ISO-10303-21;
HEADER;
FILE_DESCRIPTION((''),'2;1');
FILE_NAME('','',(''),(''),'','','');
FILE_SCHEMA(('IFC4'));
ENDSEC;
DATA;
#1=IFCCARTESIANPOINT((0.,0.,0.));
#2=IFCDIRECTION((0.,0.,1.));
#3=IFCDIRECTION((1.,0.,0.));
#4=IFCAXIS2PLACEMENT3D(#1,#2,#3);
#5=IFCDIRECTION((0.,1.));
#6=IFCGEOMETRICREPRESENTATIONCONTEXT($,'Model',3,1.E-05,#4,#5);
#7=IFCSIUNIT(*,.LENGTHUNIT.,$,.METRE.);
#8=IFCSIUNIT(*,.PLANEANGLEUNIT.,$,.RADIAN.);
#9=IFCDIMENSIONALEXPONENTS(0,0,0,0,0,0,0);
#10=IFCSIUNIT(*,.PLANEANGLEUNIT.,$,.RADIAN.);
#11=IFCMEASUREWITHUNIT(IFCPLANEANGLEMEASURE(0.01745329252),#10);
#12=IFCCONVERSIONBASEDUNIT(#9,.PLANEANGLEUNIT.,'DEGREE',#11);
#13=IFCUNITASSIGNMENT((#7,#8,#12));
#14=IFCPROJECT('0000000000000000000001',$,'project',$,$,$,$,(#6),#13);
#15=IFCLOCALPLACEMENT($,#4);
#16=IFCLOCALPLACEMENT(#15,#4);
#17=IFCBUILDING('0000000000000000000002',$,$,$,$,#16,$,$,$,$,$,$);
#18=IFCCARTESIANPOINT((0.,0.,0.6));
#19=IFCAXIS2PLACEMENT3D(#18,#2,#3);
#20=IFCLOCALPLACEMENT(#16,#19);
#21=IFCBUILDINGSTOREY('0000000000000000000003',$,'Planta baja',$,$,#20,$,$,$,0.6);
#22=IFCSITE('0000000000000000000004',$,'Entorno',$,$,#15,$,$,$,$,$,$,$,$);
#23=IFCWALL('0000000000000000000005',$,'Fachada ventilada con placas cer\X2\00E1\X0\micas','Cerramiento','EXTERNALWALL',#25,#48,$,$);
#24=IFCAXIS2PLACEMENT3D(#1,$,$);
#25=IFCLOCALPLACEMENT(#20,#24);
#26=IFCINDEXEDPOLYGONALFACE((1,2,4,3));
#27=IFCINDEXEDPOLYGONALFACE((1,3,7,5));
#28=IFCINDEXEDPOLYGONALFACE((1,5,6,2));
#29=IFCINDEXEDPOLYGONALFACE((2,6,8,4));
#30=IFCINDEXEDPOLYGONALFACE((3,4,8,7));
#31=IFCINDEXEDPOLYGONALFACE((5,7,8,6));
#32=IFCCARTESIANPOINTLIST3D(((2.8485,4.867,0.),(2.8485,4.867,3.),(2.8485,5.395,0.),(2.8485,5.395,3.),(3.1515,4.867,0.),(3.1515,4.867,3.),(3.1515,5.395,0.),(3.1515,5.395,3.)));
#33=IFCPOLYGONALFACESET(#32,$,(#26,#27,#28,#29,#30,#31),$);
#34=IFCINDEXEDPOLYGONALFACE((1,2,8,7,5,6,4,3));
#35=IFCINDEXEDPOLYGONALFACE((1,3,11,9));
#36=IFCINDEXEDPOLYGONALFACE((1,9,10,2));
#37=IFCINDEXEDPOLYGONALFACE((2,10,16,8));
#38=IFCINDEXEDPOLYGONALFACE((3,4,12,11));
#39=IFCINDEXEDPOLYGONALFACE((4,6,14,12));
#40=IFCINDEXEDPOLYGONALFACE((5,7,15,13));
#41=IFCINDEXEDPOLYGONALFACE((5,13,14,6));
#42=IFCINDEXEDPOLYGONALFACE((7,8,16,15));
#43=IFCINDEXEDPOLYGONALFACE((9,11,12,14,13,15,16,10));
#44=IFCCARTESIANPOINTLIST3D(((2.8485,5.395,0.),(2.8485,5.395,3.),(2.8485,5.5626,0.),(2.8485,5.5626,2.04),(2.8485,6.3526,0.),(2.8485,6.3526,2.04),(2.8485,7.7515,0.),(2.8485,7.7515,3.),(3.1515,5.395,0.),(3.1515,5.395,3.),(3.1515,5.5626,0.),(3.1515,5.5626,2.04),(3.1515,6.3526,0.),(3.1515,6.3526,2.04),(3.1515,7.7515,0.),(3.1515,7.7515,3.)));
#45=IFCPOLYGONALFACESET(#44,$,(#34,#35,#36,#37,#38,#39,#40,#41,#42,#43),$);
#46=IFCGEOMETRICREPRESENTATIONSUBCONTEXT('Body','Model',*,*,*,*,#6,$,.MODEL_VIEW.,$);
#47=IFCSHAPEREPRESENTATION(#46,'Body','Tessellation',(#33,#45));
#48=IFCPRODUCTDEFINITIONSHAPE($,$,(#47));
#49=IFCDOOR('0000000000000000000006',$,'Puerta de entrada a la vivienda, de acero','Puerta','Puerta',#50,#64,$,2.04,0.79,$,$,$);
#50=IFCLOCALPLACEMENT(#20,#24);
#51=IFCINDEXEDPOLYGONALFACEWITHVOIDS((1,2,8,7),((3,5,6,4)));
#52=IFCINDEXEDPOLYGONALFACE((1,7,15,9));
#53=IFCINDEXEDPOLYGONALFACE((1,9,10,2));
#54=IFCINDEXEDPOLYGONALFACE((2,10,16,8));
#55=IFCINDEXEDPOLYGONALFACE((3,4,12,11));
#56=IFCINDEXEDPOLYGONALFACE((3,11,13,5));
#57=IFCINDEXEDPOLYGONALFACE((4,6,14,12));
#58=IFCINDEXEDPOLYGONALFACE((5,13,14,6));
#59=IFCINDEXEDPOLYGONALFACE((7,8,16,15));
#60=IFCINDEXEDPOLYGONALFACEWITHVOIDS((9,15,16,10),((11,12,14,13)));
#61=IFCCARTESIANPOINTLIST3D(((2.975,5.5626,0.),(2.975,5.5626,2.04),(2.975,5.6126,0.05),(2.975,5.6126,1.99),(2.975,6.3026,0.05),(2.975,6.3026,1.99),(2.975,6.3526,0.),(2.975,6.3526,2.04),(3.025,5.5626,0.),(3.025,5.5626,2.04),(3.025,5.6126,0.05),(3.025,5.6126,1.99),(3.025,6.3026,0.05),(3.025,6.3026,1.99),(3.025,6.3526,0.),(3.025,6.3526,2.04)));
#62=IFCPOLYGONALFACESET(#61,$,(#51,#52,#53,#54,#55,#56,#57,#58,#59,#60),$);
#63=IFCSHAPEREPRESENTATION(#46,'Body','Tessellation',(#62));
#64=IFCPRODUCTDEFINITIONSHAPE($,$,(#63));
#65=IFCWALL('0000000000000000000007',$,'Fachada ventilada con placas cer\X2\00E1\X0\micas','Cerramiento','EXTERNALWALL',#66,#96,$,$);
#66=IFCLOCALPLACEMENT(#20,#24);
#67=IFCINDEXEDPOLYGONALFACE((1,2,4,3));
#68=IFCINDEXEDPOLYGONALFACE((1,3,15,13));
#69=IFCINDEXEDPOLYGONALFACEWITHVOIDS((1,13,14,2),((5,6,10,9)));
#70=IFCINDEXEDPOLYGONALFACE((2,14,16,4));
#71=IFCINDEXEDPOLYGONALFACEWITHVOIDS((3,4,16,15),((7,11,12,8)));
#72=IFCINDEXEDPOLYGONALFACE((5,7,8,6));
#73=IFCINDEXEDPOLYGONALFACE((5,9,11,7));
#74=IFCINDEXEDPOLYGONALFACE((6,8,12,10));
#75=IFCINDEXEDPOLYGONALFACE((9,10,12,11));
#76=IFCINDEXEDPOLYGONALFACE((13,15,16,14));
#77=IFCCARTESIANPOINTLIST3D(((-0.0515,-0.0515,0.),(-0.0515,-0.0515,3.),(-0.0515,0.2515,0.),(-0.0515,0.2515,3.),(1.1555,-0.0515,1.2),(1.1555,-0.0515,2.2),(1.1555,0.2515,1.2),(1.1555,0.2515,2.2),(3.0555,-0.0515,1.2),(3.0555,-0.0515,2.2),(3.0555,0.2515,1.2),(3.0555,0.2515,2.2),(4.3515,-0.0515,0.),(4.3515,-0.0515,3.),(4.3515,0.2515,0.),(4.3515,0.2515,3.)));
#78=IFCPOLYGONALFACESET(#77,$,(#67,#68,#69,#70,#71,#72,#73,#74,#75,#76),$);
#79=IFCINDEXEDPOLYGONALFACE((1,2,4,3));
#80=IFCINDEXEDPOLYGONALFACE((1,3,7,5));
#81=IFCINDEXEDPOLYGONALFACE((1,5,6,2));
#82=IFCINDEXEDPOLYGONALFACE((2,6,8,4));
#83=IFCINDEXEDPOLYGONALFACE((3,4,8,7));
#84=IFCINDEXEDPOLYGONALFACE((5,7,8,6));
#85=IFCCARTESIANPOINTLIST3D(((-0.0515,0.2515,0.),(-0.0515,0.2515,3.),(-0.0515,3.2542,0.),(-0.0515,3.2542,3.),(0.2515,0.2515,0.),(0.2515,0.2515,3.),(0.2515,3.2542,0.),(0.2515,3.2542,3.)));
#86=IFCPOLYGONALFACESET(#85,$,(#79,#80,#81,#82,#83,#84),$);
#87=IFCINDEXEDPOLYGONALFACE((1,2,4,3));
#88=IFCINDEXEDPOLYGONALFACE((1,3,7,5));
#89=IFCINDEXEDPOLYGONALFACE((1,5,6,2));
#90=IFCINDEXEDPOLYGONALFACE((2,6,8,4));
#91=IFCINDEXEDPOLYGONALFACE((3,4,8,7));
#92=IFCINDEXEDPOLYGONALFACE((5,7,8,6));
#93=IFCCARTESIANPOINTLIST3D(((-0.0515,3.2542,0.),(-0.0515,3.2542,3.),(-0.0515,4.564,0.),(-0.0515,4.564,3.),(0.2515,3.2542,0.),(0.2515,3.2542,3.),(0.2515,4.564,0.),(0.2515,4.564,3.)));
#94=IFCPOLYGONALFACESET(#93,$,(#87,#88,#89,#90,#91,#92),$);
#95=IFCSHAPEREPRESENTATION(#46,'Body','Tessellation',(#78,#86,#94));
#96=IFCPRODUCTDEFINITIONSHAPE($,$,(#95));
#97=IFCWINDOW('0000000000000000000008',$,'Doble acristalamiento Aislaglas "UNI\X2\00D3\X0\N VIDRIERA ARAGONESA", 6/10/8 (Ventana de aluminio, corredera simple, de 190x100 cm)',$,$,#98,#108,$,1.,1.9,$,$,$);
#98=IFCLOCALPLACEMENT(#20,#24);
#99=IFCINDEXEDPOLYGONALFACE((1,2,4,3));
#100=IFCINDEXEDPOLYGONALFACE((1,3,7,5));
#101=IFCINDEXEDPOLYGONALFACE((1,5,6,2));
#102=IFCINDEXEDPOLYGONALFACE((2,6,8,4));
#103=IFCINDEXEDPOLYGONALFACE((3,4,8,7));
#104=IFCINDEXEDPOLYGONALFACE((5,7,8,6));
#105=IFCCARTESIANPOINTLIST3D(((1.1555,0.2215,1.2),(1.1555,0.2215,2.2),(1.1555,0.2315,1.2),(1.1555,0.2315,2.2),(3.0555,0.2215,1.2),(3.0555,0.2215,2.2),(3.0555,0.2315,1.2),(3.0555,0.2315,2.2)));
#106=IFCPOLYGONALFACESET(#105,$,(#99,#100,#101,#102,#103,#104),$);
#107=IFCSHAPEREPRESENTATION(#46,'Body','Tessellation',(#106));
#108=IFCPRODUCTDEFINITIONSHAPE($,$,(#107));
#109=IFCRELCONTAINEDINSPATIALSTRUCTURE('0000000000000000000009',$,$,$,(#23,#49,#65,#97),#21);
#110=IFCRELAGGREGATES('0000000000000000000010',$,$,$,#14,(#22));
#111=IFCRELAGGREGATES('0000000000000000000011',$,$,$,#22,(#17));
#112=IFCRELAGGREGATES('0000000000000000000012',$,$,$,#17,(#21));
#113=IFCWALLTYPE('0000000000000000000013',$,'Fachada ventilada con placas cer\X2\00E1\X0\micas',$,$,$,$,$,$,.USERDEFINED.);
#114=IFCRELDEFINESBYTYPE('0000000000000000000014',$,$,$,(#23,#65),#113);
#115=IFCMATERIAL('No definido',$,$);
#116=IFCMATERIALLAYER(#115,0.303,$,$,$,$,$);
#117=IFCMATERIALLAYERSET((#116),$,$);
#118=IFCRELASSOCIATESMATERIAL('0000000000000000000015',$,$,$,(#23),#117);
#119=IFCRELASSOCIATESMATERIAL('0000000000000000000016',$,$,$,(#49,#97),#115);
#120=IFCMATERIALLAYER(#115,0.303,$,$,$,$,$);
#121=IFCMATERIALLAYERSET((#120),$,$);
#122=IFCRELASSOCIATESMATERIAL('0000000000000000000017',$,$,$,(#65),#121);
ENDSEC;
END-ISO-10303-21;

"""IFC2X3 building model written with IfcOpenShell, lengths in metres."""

from ifc_helpers import new_model, entity, si_unit, converted_unit, direction, frame, origin_with_axes, origin_2d_with_axis, place, context, subcontext, project, spatial, polyline, rectangle, hollow_rectangle, outline, extrude, shape, material, layer, layer_set, layer_usage, type_object, element, fill, save


model = new_model("IFC2X3")

# Units and contexts
model_context = context("Model", 3, precision=1e-05, world=origin_with_axes(), true_north=direction((0.0, 1.0)))
body_context = subcontext(model_context, "Body", "Model", "MODEL_VIEW")
footprint_context = subcontext(model_context, "FootPrint", "Model", "MODEL_VIEW")
ifc_project = project(units=[si_unit("LENGTHUNIT", "METRE"), si_unit("PLANEANGLEUNIT", "RADIAN"), converted_unit("PLANEANGLEUNIT", "DEGREE", entity("IfcPlaneAngleMeasure", 0.01745329252), si_unit("PLANEANGLEUNIT", "RADIAN"), dimensions=[0, 0, 0, 0, 0, 0, 0])], contexts=[model_context])

# Site, building, storey
site_placement = place(None, origin_with_axes())
site = spatial("IfcSite", under=ifc_project, at=site_placement, Name="Entorno")
building_placement = place(site_placement, origin_with_axes())
building = spatial("IfcBuilding", under=site, at=building_placement)
storey_placement = place(building_placement, frame((0.0, 0.0, 0.6), z_axis=(0.0, 0.0, 1.0), x_axis=(1.0, 0.0, 0.0)))
storey = spatial("IfcBuildingStorey", under=building, at=storey_placement, Name="Planta baja", Elevation=0.6)

# Shared definitions
ifc_material = material(Name="No definido")

# Shared definitions
wall_type_1 = type_object("IfcWallType", Name="Fachada ventilada con placas cerámicas", PredefinedType="USERDEFINED")

# Wall, opening, door
ifc_layer_1 = layer(ifc_material, 0.303)
ifc_layer_set_1 = layer_set([ifc_layer_1])
ifc_layer_usage_1 = layer_usage(ifc_layer_set_1, "AXIS2", "POSITIVE", -0.1515)
wall_1_placement = place(storey_placement, frame((3.0, 4.7155, 0.0), z_axis=(0.0, 0.0, 1.0), x_axis=(0.0, 1.0, 0.0)))
wall_1 = element("IfcWall", 1, at=wall_1_placement, inside=storey, type_object=wall_type_1, material=ifc_layer_usage_1, Name="Fachada ventilada con placas cerámicas", Description="Cerramiento", ObjectType="EXTERNALWALL", context=body_context, shape_type="SolidModel", body=[
    extrude(outline(polyline([(-0.264, -1.5), (0.264, -1.5), (0.264, 1.5), (-0.264, 1.5), (-0.264, -1.5)])), frame((0.4155, 0.1515, 1.5), z_axis=(0.0, -1.0, 0.0), x_axis=(1.0, 0.0, 0.0)), (0.0, 0.0, 1.0), 0.303),
    extrude(outline(polyline([(-1.1783, -1.5), (1.1783, -1.5), (1.1783, 1.5), (-1.1783, 1.5), (-1.1783, -1.5)])), frame((1.8578, 0.1515, 1.5), z_axis=(0.0, -1.0, 0.0), x_axis=(1.0, 0.0, 0.0)), (0.0, 0.0, 1.0), 0.303),
])
opening_1_placement = place(wall_1_placement, frame((1.2421, 0.0, 1.02), z_axis=(0.0, 0.0, 1.0), x_axis=(1.0, 0.0, 0.0)))
cartesian_point_1 = entity("IfcCartesianPoint", [-0.395, -0.1515])
opening_1 = element("IfcOpeningElement", 2, at=opening_1_placement, cuts=wall_1, ObjectType="No definido", shapes=[
    shape(body_context, "Body", "SweptSolid", [extrude(rectangle(XDim=2.04, YDim=0.79, at=origin_2d_with_axis()), frame((0.0, -0.1515, 0.0), z_axis=(0.0, 1.0, 0.0), x_axis=(0.0, 0.0, 1.0)), (0.0, 0.0, 1.0), 0.303)]),
    shape(footprint_context, "FootPrint", "GeometricCurveSet", [entity("IfcGeometricCurveSet", [entity("IfcPolyline", [cartesian_point_1, entity("IfcCartesianPoint", [0.395, -0.1515]), entity("IfcCartesianPoint", [0.395, 0.1515]), entity("IfcCartesianPoint", [-0.395, 0.1515]), cartesian_point_1])])]),
])
door_1_placement = place(opening_1_placement, origin_with_axes())
door_1 = element("IfcDoor", 3, at=door_1_placement, inside=storey, material=ifc_material, Name="Puerta de entrada a la vivienda, de acero", Description="Puerta", ObjectType="Puerta", OverallHeight=2.04, OverallWidth=0.79, context=body_context, shape_type="SweptSolid", body=[
    extrude(hollow_rectangle(XDim=0.79, YDim=2.04, WallThickness=0.05, InnerFilletRadius=0.0, OuterFilletRadius=0.0, at=origin_2d_with_axis()), frame((0.0, 0.025, 0.0), z_axis=(0.0, -1.0, 0.0), x_axis=(1.0, 0.0, 0.0)), (0.0, 0.0, 1.0), 0.05),
])
fill(opening_1, door_1)

# Wall, opening, window
ifc_layer_2 = layer(ifc_material, 0.303)
ifc_layer_set_2 = layer_set([ifc_layer_2])
ifc_layer_usage_2 = layer_usage(ifc_layer_set_2, "AXIS2", "POSITIVE", -0.1515)
wall_2_placement = place(storey_placement, frame((4.2, 0.1, 0.0), z_axis=(0.0, 0.0, 1.0), x_axis=(-1.0, 0.0, 0.0)))
wall_2 = element("IfcWall", 4, at=wall_2_placement, inside=storey, type_object=wall_type_1, material=ifc_layer_usage_2, Name="Fachada ventilada con placas cerámicas", Description="Cerramiento", ObjectType="EXTERNALWALL", context=body_context, shape_type="SolidModel", body=[
    extrude(outline(polyline([(-2.2015, -1.5), (2.2015, -1.5), (2.2015, 1.5), (-2.2015, 1.5), (-2.2015, -1.5)])), frame((2.05, 0.1515, 1.5), z_axis=(0.0, -1.0, 0.0), x_axis=(1.0, 0.0, 0.0)), (0.0, 0.0, 1.0), 0.303),
    extrude(outline(polyline([(-1.5013, -1.5), (1.5013, -1.5), (1.5013, 1.5), (-1.5013, 1.5), (-1.5013, -1.5)])), frame((4.2515, -1.6528, 1.5), z_axis=(-1.0, 0.0, 0.0), x_axis=(0.0, -1.0, 0.0)), (0.0, 0.0, 1.0), 0.303),
    extrude(outline(polyline([(-0.6549, -1.5), (0.6549, -1.5), (0.6549, 1.5), (-0.6549, 1.5), (-0.6549, -1.5)])), frame((4.2515, -3.8091, 1.5), z_axis=(-1.0, 0.0, 0.0), x_axis=(0.0, -1.0, 0.0)), (0.0, 0.0, 1.0), 0.303),
])
opening_2_placement = place(wall_2_placement, frame((2.0945, 0.0, 1.7), z_axis=(0.0, 0.0, 1.0), x_axis=(1.0, 0.0, 0.0)))
cartesian_point_2 = entity("IfcCartesianPoint", [-0.95, -0.1515])
opening_2 = element("IfcOpeningElement", 5, at=opening_2_placement, cuts=wall_2, ObjectType="No definido", shapes=[
    shape(body_context, "Body", "SweptSolid", [extrude(rectangle(XDim=1.0, YDim=1.9, at=origin_2d_with_axis()), frame((0.0, -0.1515, 0.0), z_axis=(0.0, 1.0, 0.0), x_axis=(0.0, 0.0, 1.0)), (0.0, 0.0, 1.0), 0.303)]),
    shape(footprint_context, "FootPrint", "GeometricCurveSet", [entity("IfcGeometricCurveSet", [entity("IfcPolyline", [cartesian_point_2, entity("IfcCartesianPoint", [0.95, -0.1515]), entity("IfcCartesianPoint", [0.95, 0.1515]), entity("IfcCartesianPoint", [-0.95, 0.1515]), cartesian_point_2])])]),
])
window_1_placement = place(opening_2_placement, frame((0.0, -0.1265, 0.0), z_axis=(0.0, 0.0, 1.0), x_axis=(1.0, 0.0, 0.0)))
window_1 = element("IfcWindow", 6, at=window_1_placement, inside=storey, material=ifc_material, Name="Doble acristalamiento Aislaglas \"UNIÓN VIDRIERA ARAGONESA\", 6/10/8 (Ventana de aluminio, corredera simple, de 190x100 cm)", OverallHeight=1.0, OverallWidth=1.9, context=body_context, shape_type="SweptSolid", body=[
    extrude(rectangle(XDim=1.9, YDim=1.0, at=origin_2d_with_axis()), frame((0.0, 0.005, 0.0), z_axis=(0.0, -1.0, 0.0), x_axis=(1.0, 0.0, 0.0)), (0.0, 0.0, 1.0), 0.01),
])
fill(opening_2, window_1)

save(model, "model.ifc")
